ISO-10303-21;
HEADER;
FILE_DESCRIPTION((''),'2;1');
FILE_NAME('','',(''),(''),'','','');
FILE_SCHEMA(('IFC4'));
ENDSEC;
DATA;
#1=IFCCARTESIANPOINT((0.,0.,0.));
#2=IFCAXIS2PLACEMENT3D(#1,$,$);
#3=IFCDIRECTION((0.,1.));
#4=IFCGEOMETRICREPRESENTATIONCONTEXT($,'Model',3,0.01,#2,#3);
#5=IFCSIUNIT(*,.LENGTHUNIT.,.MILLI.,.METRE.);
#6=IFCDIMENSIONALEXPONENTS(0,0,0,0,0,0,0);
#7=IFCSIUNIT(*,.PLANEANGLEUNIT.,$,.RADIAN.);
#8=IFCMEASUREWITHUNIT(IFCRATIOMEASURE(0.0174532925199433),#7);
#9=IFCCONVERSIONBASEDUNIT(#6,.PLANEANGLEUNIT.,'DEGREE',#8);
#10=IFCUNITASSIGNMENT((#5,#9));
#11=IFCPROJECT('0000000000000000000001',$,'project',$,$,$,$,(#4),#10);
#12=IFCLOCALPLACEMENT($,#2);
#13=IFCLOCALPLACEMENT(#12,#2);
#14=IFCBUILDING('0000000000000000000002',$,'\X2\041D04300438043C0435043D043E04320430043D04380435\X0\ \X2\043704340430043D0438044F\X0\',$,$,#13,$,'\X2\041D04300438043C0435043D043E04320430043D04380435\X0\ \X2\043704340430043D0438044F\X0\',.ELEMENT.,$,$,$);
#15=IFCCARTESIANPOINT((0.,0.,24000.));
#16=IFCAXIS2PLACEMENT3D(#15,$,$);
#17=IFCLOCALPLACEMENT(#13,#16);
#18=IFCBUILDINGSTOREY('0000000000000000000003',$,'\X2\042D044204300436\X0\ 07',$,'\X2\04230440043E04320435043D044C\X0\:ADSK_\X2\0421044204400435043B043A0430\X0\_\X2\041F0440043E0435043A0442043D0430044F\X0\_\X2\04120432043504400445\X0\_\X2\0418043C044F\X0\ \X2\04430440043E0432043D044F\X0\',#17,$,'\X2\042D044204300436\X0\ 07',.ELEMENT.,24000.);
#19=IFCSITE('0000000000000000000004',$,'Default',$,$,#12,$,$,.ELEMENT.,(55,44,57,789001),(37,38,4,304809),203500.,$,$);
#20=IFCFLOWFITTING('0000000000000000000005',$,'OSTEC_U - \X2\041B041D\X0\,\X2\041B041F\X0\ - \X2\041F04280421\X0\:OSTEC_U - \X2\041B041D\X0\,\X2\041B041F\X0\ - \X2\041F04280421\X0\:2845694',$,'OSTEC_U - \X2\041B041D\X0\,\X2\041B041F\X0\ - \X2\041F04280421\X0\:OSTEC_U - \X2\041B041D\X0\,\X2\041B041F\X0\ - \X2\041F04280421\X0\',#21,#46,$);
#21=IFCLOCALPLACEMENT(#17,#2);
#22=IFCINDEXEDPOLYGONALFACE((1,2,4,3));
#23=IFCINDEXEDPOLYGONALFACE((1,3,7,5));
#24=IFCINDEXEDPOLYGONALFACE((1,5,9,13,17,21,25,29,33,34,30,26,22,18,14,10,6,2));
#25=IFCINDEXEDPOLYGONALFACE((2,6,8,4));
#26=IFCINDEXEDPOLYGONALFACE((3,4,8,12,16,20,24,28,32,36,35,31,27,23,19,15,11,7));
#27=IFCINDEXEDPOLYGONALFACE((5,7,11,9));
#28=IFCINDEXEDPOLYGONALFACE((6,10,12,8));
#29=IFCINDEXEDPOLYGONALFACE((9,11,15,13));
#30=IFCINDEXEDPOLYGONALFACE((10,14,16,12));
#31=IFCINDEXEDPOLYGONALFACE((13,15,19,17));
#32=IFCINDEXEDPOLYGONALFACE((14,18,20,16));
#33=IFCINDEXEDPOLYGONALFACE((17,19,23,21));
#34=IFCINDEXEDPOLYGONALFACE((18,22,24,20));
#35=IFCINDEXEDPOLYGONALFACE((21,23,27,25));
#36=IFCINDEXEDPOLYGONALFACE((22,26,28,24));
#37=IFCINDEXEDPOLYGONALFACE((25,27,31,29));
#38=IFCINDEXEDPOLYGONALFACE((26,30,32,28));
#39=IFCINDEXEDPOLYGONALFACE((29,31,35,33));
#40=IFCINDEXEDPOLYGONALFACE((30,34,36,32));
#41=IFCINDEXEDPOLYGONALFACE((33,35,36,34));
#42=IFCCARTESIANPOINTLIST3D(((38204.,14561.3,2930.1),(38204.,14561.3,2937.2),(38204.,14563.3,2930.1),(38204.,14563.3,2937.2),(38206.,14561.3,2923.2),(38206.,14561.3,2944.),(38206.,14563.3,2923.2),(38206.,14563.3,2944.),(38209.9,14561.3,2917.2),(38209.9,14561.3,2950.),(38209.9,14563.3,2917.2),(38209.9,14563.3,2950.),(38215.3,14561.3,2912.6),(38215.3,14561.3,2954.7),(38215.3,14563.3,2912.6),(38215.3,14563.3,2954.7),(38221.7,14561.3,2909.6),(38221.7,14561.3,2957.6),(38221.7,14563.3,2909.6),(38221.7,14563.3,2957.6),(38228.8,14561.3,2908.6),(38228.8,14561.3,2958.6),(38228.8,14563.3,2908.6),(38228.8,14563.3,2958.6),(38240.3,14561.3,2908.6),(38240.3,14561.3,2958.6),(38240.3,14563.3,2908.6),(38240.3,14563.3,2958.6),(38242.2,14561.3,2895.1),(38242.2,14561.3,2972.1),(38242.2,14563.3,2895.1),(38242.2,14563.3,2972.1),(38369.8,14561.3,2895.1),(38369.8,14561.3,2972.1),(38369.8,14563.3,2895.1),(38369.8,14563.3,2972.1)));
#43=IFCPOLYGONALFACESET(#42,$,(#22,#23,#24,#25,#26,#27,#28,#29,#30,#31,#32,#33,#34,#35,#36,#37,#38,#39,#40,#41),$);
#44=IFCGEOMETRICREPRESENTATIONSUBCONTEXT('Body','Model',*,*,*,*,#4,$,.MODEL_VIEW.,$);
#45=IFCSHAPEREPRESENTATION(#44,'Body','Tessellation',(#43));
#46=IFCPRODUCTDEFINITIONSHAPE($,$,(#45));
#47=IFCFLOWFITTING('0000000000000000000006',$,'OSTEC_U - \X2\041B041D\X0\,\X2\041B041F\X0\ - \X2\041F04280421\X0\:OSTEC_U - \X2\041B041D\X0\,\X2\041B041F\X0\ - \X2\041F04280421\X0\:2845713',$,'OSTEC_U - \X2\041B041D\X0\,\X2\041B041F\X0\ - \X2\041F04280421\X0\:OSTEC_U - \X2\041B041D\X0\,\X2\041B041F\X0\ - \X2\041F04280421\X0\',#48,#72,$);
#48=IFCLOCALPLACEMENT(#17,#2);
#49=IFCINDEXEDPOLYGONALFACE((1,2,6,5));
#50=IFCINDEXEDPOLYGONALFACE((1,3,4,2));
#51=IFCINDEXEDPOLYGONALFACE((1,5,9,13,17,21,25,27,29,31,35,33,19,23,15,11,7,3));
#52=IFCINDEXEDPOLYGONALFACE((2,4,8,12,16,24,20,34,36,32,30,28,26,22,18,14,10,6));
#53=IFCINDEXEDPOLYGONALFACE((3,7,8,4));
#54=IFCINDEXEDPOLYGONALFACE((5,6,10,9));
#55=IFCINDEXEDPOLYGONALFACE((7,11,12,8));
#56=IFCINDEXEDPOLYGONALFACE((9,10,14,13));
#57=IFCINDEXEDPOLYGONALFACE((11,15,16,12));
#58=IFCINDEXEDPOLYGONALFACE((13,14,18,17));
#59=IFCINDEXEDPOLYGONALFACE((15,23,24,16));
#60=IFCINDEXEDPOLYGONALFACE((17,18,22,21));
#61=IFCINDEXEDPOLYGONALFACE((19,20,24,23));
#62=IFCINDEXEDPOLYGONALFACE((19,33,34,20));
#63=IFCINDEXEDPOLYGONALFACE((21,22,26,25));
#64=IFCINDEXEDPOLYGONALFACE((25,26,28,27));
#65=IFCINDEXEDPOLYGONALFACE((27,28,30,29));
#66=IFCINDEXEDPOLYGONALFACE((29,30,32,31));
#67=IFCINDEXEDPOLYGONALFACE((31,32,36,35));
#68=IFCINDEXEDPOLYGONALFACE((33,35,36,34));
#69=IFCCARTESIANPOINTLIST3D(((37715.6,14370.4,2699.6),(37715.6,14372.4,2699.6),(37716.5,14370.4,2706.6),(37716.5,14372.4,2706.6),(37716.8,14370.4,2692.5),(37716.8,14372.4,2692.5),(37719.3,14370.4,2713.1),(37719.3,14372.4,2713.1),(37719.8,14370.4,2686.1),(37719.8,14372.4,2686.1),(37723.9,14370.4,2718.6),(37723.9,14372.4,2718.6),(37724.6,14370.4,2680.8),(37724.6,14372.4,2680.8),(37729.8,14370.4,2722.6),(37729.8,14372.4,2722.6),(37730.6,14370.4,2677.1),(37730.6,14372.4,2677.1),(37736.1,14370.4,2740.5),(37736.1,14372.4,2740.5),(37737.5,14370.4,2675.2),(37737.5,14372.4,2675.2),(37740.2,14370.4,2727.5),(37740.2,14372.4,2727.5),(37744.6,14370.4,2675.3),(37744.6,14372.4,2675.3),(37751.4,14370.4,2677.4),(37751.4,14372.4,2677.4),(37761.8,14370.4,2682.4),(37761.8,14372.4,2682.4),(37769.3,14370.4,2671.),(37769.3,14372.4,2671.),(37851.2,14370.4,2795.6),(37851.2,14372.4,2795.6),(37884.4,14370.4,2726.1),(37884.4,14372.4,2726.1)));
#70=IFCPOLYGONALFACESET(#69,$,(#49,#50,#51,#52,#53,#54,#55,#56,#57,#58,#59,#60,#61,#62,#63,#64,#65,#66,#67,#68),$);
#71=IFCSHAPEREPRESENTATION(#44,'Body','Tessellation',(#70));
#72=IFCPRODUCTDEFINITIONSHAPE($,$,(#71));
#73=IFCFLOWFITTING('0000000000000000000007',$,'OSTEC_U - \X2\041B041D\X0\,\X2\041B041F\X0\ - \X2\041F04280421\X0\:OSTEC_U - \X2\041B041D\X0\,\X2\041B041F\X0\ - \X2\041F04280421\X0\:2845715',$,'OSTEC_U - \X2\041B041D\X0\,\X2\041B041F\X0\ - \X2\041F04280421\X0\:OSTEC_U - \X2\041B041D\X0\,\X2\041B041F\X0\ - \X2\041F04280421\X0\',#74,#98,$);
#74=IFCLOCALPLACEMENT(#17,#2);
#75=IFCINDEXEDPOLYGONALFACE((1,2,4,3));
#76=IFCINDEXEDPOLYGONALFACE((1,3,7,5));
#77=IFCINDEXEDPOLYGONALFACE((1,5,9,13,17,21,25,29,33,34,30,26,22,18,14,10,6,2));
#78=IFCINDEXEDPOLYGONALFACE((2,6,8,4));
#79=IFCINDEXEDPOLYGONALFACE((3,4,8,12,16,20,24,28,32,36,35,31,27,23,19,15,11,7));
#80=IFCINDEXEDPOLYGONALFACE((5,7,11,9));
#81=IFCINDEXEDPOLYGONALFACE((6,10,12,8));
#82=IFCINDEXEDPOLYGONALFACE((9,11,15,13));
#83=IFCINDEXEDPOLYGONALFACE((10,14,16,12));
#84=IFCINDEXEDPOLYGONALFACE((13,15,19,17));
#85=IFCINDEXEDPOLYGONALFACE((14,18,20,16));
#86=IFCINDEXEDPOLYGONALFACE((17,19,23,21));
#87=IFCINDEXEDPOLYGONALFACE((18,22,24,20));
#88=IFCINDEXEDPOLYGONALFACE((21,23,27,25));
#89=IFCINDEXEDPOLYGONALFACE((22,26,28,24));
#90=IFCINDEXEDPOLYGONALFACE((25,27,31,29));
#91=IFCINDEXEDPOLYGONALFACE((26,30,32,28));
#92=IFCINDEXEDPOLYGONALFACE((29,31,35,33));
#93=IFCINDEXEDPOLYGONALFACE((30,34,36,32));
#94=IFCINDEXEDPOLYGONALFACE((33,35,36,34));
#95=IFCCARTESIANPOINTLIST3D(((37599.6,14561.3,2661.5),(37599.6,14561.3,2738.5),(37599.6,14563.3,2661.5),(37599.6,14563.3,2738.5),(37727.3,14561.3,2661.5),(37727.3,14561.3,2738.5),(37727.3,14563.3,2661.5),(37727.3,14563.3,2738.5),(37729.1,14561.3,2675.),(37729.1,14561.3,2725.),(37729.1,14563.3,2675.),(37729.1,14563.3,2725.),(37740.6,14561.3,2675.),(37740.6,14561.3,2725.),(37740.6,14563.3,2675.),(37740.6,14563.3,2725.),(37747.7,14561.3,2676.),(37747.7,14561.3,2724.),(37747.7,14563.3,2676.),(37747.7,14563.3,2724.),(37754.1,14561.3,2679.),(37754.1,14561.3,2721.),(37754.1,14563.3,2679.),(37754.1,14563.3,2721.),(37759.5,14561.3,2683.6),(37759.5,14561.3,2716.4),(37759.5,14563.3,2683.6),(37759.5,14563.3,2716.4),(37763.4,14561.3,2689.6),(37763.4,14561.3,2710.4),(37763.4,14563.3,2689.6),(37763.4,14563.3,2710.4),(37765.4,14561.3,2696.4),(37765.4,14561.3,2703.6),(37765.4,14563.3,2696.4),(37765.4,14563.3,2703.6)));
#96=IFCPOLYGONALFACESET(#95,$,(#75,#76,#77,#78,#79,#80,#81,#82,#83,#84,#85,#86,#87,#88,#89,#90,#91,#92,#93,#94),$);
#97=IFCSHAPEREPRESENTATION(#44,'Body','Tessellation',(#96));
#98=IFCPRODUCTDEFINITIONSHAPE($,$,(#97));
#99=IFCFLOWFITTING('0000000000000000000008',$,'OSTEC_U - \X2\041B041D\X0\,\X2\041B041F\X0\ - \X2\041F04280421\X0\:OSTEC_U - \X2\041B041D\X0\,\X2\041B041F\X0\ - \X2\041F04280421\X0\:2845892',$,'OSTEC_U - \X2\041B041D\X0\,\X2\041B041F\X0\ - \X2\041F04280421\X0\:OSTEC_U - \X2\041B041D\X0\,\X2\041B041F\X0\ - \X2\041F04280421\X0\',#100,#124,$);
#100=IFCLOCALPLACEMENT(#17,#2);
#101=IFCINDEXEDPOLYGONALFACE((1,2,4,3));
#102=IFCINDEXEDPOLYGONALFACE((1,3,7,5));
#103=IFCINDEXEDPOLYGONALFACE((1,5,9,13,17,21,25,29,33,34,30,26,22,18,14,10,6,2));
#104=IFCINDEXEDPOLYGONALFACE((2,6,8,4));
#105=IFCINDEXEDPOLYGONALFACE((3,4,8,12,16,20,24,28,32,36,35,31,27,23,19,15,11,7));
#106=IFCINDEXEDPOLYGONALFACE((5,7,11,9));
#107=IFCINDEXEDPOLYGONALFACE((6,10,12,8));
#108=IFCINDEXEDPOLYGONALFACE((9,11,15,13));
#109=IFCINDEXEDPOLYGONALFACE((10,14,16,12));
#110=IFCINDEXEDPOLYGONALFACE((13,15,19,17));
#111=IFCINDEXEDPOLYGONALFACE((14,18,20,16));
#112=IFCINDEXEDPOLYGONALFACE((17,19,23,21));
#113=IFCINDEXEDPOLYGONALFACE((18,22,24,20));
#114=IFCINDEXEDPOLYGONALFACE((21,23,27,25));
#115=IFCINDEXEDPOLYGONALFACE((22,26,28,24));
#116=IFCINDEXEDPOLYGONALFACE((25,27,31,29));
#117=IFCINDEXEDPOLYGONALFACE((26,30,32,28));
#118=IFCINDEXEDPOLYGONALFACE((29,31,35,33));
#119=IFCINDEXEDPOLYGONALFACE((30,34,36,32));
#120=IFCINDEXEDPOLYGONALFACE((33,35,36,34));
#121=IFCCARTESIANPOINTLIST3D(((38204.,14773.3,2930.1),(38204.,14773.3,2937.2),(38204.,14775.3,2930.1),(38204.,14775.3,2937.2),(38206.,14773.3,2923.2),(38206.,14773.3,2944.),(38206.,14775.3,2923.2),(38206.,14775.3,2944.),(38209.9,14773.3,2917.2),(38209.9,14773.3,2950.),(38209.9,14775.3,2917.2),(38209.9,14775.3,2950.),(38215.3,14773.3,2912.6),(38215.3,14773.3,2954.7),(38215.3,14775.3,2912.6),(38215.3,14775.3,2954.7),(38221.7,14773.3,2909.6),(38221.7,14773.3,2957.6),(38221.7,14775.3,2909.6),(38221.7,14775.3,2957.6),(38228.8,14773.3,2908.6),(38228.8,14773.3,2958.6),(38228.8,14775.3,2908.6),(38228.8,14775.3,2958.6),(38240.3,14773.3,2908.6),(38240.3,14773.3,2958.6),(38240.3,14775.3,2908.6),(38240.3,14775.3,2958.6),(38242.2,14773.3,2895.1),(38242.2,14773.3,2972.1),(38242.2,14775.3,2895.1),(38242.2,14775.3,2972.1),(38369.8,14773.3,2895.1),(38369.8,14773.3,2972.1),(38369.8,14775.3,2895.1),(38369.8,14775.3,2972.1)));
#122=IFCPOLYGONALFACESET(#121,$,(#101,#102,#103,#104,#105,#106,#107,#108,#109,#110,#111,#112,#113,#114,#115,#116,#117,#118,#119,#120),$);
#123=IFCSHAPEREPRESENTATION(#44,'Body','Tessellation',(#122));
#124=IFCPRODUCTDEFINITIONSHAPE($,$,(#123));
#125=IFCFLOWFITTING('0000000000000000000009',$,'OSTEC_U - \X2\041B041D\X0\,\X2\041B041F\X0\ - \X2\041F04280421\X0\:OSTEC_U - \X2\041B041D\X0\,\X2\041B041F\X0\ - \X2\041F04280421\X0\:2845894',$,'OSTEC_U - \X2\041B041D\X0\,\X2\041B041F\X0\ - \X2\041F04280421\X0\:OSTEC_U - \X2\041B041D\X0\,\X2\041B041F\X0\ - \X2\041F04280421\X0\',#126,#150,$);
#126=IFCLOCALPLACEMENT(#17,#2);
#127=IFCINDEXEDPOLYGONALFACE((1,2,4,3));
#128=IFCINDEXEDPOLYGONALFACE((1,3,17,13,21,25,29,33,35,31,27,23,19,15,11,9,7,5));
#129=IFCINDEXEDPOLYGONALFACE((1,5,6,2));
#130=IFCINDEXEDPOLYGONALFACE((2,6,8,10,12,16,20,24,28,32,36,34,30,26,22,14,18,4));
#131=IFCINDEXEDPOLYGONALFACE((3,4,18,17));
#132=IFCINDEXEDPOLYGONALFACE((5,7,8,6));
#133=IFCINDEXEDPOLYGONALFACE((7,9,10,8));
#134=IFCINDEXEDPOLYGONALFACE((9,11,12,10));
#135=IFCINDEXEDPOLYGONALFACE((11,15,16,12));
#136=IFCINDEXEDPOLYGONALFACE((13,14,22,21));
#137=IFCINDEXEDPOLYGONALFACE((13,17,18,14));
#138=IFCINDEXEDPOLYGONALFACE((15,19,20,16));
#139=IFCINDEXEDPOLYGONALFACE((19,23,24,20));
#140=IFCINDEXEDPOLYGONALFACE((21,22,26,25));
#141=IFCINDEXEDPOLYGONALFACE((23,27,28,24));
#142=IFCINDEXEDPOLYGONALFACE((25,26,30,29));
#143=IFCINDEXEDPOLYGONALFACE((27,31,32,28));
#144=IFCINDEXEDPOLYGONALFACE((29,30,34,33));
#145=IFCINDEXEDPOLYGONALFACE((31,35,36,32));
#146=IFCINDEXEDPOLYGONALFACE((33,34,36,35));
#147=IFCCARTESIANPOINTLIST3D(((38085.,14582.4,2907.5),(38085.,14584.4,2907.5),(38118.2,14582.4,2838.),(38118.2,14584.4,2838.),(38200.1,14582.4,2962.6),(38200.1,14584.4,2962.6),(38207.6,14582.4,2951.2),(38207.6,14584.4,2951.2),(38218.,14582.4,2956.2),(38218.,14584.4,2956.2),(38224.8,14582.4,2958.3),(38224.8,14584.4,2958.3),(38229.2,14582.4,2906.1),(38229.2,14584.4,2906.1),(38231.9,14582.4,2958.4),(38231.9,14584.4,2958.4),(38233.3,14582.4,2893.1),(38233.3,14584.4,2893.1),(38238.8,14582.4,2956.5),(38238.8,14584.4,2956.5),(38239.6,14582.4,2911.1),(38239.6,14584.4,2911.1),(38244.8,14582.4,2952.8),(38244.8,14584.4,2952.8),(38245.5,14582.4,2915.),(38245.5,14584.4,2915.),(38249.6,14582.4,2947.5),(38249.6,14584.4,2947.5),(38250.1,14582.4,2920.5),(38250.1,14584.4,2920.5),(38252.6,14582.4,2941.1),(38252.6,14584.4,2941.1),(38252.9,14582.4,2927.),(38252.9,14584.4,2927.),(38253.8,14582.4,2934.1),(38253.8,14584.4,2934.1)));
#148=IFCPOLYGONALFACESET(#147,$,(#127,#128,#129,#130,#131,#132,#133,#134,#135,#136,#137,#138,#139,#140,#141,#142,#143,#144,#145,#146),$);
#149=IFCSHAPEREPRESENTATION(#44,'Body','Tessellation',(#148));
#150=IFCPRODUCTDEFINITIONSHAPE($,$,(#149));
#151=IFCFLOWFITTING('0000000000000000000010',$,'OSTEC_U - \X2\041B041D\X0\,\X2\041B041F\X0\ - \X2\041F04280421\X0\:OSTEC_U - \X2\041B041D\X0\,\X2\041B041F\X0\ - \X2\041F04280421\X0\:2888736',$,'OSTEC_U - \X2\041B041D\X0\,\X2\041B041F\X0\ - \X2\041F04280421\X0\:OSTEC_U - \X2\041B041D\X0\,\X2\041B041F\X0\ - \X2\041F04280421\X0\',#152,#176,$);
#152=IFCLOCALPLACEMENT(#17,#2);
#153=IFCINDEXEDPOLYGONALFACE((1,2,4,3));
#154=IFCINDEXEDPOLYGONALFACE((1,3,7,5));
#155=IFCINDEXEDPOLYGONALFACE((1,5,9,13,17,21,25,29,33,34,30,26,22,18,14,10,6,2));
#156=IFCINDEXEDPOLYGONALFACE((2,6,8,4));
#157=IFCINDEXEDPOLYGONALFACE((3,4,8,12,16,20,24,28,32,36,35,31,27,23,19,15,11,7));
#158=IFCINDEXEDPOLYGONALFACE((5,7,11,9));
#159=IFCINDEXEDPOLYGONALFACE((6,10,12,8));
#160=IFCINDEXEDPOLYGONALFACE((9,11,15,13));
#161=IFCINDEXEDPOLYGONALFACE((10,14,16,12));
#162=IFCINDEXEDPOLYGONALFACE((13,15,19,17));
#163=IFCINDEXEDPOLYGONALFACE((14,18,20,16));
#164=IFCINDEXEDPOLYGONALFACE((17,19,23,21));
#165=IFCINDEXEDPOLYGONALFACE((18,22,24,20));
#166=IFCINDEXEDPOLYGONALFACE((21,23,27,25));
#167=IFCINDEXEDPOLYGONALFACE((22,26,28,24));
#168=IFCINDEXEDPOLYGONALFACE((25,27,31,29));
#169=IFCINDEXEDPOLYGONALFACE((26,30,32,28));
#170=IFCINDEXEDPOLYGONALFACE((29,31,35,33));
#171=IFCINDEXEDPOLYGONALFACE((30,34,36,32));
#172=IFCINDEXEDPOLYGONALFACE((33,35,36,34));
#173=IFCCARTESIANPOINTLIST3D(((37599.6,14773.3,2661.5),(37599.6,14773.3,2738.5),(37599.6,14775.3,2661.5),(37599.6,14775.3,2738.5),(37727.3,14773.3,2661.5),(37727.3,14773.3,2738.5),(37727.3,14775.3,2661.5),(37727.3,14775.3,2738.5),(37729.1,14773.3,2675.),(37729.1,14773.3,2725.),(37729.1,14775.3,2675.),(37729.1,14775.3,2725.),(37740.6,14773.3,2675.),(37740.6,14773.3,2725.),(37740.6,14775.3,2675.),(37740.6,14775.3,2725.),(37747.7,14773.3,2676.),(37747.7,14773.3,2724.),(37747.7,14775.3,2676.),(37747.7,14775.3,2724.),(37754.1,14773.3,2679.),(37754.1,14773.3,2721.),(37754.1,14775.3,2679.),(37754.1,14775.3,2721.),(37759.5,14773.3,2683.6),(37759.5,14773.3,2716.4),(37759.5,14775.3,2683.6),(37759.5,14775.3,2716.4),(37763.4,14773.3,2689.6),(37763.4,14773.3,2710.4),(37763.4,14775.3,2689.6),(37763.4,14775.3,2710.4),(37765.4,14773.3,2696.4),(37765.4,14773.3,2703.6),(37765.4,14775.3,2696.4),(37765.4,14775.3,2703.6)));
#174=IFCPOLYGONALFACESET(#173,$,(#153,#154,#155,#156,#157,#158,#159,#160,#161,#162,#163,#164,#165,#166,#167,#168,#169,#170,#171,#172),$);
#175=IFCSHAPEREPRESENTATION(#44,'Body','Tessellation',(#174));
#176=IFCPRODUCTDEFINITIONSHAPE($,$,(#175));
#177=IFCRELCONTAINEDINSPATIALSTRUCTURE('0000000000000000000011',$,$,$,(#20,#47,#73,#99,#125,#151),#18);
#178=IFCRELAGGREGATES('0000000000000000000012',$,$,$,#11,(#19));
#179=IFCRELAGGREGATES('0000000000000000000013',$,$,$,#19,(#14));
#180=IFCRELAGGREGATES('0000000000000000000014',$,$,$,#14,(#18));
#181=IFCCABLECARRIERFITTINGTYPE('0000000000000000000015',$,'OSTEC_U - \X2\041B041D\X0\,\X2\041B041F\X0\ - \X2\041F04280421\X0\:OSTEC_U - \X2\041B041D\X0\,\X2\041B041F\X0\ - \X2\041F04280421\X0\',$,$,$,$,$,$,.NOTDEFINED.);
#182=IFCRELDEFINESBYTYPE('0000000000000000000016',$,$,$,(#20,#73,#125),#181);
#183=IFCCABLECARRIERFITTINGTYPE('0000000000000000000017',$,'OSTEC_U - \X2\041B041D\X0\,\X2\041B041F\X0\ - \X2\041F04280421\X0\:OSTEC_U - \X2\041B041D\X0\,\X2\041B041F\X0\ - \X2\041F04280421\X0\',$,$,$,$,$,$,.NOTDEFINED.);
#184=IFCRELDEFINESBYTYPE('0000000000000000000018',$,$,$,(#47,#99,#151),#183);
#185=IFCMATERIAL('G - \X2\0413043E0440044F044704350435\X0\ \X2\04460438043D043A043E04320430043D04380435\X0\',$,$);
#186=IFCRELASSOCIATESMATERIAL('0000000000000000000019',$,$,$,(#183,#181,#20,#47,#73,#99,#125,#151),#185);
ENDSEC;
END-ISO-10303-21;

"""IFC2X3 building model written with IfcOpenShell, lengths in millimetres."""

from ifc_helpers import new_model, entity, si_unit, converted_unit, direction, frame, frame_2d, origin, place, context, subcontext, project, spatial, polyline, circle_curve, parameter, trimmed, segment, composite_curve, outline, extrude, source, transform, mapped, material, type_object, type_shapes, element, save


model = new_model("IFC2X3")

# Units and contexts
model_context = context("Model", 3, precision=0.01, world=origin(), true_north=direction((0.0, 1.0)))
body_context = subcontext(model_context, "Body", "Model", "MODEL_VIEW")
ifc_project = project(units=[si_unit("LENGTHUNIT", "METRE", prefix="MILLI"), converted_unit("PLANEANGLEUNIT", "DEGREE", entity("IfcRatioMeasure", 0.0174532925199433), si_unit("PLANEANGLEUNIT", "RADIAN"), dimensions=[0, 0, 0, 0, 0, 0, 0])], contexts=[model_context])

# Site, building, storey
site_placement = place(None, origin())
site = spatial("IfcSite", under=ifc_project, at=site_placement, Name="Default", CompositionType="ELEMENT", RefLatitude=(55, 44, 57, 789001), RefLongitude=(37, 38, 4, 304809), RefElevation=203500.0)
building_placement = place(site_placement, origin())
building = spatial("IfcBuilding", under=site, at=building_placement, Name="Наименование здания", LongName="Наименование здания", CompositionType="ELEMENT")
storey_placement = place(building_placement, frame((0.0, 0.0, 24000.0)))
storey = spatial("IfcBuildingStorey", under=building, at=storey_placement, Name="Этаж 07", ObjectType="Уровень:ADSK_Стрелка_Проектная_Вверх_Имя уровня", LongName="Этаж 07", CompositionType="ELEMENT", Elevation=24000.0)

# Flow fittings
ifc_material_1 = material(Name="G - Горячее цинкование")
cable_carrier_fitting_type_1 = type_object("IfcCableCarrierFittingType", Name="OSTEC_U - ЛН,ЛП - ПШС:OSTEC_U - ЛН,ЛП - ПШС", PredefinedType="NOTDEFINED", material=ifc_material_1)
shared_shape_1 = source(origin(), body_context, "Body", "SweptSolid", [
    extrude(outline(composite_curve([segment(trimmed(circle_curve(frame_2d((-41.5, 0.0), x_axis=(1.0, 0.0)), 25.0), [parameter(90.0)], [parameter(270.0)], True, "PARAMETER"), True, "CONTINUOUS"), segment(polyline([(-41.5, -25.0), (-30.0, -25.0)]), True, "CONTINUOUS"), segment(polyline([(-30.0, -25.0), (-28.1, -38.5)]), True, "CONTINUOUS"), segment(polyline([(-28.1, -38.5), (99.5, -38.5)]), True, "CONTINUOUS"), segment(polyline([(99.5, -38.5), (99.5, 38.5)]), True, "CONTINUOUS"), segment(polyline([(99.5, 38.5), (-28.1, 38.5)]), True, "CONTINUOUS"), segment(polyline([(-28.1, 38.5), (-30.0, 25.0)]), True, "CONTINUOUS"), segment(polyline([(-30.0, 25.0), (-41.5, 25.0)]), True, "CONTINUOUS")], self_intersect=False)), frame((41.5, 0.0, 0.0), z_axis=(0.0, 0.0, -1.0), x_axis=(1.0, 0.0, 0.0)), (0.0, 0.0, -1.0), 2.0),
])
type_shapes(cable_carrier_fitting_type_1, [shared_shape_1])
cable_carrier_fitting_type_2 = type_object("IfcCableCarrierFittingType", Name="OSTEC_U - ЛН,ЛП - ПШС:OSTEC_U - ЛН,ЛП - ПШС", PredefinedType="NOTDEFINED", material=ifc_material_1)
type_shapes(cable_carrier_fitting_type_2, [shared_shape_1])
flow_fitting_1_placement = place(storey_placement, frame((38228.8, 14561.3, 2933.6), z_axis=(0.0, 1.0, 0.0), x_axis=(1.0, 0.0, 0.0)))
element("IfcFlowFitting", 1, at=flow_fitting_1_placement, inside=storey, type_object=cable_carrier_fitting_type_2, material=ifc_material_1, Name="OSTEC_U - ЛН,ЛП - ПШС:OSTEC_U - ЛН,ЛП - ПШС:2845694", ObjectType="OSTEC_U - ЛН,ЛП - ПШС:OSTEC_U - ЛН,ЛП - ПШС", context=body_context, shape_type="MappedRepresentation", body=[
    mapped(shared_shape_1, transform((0.0, 0.0, 0.0), scale=1.0)),
])
flow_fitting_2_placement = place(storey_placement, frame((37740.6, 14372.4, 2700.0), z_axis=(0.0, -1.0, 0.0), x_axis=(0.90203, 0.0, 0.431673)))
element("IfcFlowFitting", 2, at=flow_fitting_2_placement, inside=storey, type_object=cable_carrier_fitting_type_1, material=ifc_material_1, Name="OSTEC_U - ЛН,ЛП - ПШС:OSTEC_U - ЛН,ЛП - ПШС:2845713", ObjectType="OSTEC_U - ЛН,ЛП - ПШС:OSTEC_U - ЛН,ЛП - ПШС", context=body_context, shape_type="MappedRepresentation", body=[
    mapped(shared_shape_1, transform((0.0, 0.0, 0.0), scale=1.0)),
])
flow_fitting_3_placement = place(storey_placement, frame((37740.6, 14561.3, 2700.0), z_axis=(0.0, 1.0, 0.0), x_axis=(-1.0, 0.0, 0.0)))
element("IfcFlowFitting", 3, at=flow_fitting_3_placement, inside=storey, type_object=cable_carrier_fitting_type_2, material=ifc_material_1, Name="OSTEC_U - ЛН,ЛП - ПШС:OSTEC_U - ЛН,ЛП - ПШС:2845715", ObjectType="OSTEC_U - ЛН,ЛП - ПШС:OSTEC_U - ЛН,ЛП - ПШС", context=body_context, shape_type="MappedRepresentation", body=[
    mapped(shared_shape_1, transform((0.0, 0.0, 0.0), scale=1.0)),
])
flow_fitting_4_placement = place(storey_placement, frame((38228.8, 14773.3, 2933.6), z_axis=(0.0, 1.0, 0.0), x_axis=(1.0, 0.0, 0.0)))
element("IfcFlowFitting", 4, at=flow_fitting_4_placement, inside=storey, type_object=cable_carrier_fitting_type_1, material=ifc_material_1, Name="OSTEC_U - ЛН,ЛП - ПШС:OSTEC_U - ЛН,ЛП - ПШС:2845892", ObjectType="OSTEC_U - ЛН,ЛП - ПШС:OSTEC_U - ЛН,ЛП - ПШС", context=body_context, shape_type="MappedRepresentation", body=[
    mapped(shared_shape_1, transform((0.0, 0.0, 0.0), scale=1.0)),
])
flow_fitting_5_placement = place(storey_placement, frame((38228.8, 14584.4, 2933.6), z_axis=(0.0, -1.0, 0.0), x_axis=(-0.90203, 0.0, -0.431673)))
element("IfcFlowFitting", 5, at=flow_fitting_5_placement, inside=storey, type_object=cable_carrier_fitting_type_2, material=ifc_material_1, Name="OSTEC_U - ЛН,ЛП - ПШС:OSTEC_U - ЛН,ЛП - ПШС:2845894", ObjectType="OSTEC_U - ЛН,ЛП - ПШС:OSTEC_U - ЛН,ЛП - ПШС", context=body_context, shape_type="MappedRepresentation", body=[
    mapped(shared_shape_1, transform((0.0, 0.0, 0.0), scale=1.0)),
])
flow_fitting_6_placement = place(storey_placement, frame((37740.6, 14773.3, 2700.0), z_axis=(0.0, 1.0, 0.0), x_axis=(-1.0, 0.0, 0.0)))
element("IfcFlowFitting", 6, at=flow_fitting_6_placement, inside=storey, type_object=cable_carrier_fitting_type_1, material=ifc_material_1, Name="OSTEC_U - ЛН,ЛП - ПШС:OSTEC_U - ЛН,ЛП - ПШС:2888736", ObjectType="OSTEC_U - ЛН,ЛП - ПШС:OSTEC_U - ЛН,ЛП - ПШС", context=body_context, shape_type="MappedRepresentation", body=[
    mapped(shared_shape_1, transform((0.0, 0.0, 0.0), scale=1.0)),
])

save(model, "model.ifc")
